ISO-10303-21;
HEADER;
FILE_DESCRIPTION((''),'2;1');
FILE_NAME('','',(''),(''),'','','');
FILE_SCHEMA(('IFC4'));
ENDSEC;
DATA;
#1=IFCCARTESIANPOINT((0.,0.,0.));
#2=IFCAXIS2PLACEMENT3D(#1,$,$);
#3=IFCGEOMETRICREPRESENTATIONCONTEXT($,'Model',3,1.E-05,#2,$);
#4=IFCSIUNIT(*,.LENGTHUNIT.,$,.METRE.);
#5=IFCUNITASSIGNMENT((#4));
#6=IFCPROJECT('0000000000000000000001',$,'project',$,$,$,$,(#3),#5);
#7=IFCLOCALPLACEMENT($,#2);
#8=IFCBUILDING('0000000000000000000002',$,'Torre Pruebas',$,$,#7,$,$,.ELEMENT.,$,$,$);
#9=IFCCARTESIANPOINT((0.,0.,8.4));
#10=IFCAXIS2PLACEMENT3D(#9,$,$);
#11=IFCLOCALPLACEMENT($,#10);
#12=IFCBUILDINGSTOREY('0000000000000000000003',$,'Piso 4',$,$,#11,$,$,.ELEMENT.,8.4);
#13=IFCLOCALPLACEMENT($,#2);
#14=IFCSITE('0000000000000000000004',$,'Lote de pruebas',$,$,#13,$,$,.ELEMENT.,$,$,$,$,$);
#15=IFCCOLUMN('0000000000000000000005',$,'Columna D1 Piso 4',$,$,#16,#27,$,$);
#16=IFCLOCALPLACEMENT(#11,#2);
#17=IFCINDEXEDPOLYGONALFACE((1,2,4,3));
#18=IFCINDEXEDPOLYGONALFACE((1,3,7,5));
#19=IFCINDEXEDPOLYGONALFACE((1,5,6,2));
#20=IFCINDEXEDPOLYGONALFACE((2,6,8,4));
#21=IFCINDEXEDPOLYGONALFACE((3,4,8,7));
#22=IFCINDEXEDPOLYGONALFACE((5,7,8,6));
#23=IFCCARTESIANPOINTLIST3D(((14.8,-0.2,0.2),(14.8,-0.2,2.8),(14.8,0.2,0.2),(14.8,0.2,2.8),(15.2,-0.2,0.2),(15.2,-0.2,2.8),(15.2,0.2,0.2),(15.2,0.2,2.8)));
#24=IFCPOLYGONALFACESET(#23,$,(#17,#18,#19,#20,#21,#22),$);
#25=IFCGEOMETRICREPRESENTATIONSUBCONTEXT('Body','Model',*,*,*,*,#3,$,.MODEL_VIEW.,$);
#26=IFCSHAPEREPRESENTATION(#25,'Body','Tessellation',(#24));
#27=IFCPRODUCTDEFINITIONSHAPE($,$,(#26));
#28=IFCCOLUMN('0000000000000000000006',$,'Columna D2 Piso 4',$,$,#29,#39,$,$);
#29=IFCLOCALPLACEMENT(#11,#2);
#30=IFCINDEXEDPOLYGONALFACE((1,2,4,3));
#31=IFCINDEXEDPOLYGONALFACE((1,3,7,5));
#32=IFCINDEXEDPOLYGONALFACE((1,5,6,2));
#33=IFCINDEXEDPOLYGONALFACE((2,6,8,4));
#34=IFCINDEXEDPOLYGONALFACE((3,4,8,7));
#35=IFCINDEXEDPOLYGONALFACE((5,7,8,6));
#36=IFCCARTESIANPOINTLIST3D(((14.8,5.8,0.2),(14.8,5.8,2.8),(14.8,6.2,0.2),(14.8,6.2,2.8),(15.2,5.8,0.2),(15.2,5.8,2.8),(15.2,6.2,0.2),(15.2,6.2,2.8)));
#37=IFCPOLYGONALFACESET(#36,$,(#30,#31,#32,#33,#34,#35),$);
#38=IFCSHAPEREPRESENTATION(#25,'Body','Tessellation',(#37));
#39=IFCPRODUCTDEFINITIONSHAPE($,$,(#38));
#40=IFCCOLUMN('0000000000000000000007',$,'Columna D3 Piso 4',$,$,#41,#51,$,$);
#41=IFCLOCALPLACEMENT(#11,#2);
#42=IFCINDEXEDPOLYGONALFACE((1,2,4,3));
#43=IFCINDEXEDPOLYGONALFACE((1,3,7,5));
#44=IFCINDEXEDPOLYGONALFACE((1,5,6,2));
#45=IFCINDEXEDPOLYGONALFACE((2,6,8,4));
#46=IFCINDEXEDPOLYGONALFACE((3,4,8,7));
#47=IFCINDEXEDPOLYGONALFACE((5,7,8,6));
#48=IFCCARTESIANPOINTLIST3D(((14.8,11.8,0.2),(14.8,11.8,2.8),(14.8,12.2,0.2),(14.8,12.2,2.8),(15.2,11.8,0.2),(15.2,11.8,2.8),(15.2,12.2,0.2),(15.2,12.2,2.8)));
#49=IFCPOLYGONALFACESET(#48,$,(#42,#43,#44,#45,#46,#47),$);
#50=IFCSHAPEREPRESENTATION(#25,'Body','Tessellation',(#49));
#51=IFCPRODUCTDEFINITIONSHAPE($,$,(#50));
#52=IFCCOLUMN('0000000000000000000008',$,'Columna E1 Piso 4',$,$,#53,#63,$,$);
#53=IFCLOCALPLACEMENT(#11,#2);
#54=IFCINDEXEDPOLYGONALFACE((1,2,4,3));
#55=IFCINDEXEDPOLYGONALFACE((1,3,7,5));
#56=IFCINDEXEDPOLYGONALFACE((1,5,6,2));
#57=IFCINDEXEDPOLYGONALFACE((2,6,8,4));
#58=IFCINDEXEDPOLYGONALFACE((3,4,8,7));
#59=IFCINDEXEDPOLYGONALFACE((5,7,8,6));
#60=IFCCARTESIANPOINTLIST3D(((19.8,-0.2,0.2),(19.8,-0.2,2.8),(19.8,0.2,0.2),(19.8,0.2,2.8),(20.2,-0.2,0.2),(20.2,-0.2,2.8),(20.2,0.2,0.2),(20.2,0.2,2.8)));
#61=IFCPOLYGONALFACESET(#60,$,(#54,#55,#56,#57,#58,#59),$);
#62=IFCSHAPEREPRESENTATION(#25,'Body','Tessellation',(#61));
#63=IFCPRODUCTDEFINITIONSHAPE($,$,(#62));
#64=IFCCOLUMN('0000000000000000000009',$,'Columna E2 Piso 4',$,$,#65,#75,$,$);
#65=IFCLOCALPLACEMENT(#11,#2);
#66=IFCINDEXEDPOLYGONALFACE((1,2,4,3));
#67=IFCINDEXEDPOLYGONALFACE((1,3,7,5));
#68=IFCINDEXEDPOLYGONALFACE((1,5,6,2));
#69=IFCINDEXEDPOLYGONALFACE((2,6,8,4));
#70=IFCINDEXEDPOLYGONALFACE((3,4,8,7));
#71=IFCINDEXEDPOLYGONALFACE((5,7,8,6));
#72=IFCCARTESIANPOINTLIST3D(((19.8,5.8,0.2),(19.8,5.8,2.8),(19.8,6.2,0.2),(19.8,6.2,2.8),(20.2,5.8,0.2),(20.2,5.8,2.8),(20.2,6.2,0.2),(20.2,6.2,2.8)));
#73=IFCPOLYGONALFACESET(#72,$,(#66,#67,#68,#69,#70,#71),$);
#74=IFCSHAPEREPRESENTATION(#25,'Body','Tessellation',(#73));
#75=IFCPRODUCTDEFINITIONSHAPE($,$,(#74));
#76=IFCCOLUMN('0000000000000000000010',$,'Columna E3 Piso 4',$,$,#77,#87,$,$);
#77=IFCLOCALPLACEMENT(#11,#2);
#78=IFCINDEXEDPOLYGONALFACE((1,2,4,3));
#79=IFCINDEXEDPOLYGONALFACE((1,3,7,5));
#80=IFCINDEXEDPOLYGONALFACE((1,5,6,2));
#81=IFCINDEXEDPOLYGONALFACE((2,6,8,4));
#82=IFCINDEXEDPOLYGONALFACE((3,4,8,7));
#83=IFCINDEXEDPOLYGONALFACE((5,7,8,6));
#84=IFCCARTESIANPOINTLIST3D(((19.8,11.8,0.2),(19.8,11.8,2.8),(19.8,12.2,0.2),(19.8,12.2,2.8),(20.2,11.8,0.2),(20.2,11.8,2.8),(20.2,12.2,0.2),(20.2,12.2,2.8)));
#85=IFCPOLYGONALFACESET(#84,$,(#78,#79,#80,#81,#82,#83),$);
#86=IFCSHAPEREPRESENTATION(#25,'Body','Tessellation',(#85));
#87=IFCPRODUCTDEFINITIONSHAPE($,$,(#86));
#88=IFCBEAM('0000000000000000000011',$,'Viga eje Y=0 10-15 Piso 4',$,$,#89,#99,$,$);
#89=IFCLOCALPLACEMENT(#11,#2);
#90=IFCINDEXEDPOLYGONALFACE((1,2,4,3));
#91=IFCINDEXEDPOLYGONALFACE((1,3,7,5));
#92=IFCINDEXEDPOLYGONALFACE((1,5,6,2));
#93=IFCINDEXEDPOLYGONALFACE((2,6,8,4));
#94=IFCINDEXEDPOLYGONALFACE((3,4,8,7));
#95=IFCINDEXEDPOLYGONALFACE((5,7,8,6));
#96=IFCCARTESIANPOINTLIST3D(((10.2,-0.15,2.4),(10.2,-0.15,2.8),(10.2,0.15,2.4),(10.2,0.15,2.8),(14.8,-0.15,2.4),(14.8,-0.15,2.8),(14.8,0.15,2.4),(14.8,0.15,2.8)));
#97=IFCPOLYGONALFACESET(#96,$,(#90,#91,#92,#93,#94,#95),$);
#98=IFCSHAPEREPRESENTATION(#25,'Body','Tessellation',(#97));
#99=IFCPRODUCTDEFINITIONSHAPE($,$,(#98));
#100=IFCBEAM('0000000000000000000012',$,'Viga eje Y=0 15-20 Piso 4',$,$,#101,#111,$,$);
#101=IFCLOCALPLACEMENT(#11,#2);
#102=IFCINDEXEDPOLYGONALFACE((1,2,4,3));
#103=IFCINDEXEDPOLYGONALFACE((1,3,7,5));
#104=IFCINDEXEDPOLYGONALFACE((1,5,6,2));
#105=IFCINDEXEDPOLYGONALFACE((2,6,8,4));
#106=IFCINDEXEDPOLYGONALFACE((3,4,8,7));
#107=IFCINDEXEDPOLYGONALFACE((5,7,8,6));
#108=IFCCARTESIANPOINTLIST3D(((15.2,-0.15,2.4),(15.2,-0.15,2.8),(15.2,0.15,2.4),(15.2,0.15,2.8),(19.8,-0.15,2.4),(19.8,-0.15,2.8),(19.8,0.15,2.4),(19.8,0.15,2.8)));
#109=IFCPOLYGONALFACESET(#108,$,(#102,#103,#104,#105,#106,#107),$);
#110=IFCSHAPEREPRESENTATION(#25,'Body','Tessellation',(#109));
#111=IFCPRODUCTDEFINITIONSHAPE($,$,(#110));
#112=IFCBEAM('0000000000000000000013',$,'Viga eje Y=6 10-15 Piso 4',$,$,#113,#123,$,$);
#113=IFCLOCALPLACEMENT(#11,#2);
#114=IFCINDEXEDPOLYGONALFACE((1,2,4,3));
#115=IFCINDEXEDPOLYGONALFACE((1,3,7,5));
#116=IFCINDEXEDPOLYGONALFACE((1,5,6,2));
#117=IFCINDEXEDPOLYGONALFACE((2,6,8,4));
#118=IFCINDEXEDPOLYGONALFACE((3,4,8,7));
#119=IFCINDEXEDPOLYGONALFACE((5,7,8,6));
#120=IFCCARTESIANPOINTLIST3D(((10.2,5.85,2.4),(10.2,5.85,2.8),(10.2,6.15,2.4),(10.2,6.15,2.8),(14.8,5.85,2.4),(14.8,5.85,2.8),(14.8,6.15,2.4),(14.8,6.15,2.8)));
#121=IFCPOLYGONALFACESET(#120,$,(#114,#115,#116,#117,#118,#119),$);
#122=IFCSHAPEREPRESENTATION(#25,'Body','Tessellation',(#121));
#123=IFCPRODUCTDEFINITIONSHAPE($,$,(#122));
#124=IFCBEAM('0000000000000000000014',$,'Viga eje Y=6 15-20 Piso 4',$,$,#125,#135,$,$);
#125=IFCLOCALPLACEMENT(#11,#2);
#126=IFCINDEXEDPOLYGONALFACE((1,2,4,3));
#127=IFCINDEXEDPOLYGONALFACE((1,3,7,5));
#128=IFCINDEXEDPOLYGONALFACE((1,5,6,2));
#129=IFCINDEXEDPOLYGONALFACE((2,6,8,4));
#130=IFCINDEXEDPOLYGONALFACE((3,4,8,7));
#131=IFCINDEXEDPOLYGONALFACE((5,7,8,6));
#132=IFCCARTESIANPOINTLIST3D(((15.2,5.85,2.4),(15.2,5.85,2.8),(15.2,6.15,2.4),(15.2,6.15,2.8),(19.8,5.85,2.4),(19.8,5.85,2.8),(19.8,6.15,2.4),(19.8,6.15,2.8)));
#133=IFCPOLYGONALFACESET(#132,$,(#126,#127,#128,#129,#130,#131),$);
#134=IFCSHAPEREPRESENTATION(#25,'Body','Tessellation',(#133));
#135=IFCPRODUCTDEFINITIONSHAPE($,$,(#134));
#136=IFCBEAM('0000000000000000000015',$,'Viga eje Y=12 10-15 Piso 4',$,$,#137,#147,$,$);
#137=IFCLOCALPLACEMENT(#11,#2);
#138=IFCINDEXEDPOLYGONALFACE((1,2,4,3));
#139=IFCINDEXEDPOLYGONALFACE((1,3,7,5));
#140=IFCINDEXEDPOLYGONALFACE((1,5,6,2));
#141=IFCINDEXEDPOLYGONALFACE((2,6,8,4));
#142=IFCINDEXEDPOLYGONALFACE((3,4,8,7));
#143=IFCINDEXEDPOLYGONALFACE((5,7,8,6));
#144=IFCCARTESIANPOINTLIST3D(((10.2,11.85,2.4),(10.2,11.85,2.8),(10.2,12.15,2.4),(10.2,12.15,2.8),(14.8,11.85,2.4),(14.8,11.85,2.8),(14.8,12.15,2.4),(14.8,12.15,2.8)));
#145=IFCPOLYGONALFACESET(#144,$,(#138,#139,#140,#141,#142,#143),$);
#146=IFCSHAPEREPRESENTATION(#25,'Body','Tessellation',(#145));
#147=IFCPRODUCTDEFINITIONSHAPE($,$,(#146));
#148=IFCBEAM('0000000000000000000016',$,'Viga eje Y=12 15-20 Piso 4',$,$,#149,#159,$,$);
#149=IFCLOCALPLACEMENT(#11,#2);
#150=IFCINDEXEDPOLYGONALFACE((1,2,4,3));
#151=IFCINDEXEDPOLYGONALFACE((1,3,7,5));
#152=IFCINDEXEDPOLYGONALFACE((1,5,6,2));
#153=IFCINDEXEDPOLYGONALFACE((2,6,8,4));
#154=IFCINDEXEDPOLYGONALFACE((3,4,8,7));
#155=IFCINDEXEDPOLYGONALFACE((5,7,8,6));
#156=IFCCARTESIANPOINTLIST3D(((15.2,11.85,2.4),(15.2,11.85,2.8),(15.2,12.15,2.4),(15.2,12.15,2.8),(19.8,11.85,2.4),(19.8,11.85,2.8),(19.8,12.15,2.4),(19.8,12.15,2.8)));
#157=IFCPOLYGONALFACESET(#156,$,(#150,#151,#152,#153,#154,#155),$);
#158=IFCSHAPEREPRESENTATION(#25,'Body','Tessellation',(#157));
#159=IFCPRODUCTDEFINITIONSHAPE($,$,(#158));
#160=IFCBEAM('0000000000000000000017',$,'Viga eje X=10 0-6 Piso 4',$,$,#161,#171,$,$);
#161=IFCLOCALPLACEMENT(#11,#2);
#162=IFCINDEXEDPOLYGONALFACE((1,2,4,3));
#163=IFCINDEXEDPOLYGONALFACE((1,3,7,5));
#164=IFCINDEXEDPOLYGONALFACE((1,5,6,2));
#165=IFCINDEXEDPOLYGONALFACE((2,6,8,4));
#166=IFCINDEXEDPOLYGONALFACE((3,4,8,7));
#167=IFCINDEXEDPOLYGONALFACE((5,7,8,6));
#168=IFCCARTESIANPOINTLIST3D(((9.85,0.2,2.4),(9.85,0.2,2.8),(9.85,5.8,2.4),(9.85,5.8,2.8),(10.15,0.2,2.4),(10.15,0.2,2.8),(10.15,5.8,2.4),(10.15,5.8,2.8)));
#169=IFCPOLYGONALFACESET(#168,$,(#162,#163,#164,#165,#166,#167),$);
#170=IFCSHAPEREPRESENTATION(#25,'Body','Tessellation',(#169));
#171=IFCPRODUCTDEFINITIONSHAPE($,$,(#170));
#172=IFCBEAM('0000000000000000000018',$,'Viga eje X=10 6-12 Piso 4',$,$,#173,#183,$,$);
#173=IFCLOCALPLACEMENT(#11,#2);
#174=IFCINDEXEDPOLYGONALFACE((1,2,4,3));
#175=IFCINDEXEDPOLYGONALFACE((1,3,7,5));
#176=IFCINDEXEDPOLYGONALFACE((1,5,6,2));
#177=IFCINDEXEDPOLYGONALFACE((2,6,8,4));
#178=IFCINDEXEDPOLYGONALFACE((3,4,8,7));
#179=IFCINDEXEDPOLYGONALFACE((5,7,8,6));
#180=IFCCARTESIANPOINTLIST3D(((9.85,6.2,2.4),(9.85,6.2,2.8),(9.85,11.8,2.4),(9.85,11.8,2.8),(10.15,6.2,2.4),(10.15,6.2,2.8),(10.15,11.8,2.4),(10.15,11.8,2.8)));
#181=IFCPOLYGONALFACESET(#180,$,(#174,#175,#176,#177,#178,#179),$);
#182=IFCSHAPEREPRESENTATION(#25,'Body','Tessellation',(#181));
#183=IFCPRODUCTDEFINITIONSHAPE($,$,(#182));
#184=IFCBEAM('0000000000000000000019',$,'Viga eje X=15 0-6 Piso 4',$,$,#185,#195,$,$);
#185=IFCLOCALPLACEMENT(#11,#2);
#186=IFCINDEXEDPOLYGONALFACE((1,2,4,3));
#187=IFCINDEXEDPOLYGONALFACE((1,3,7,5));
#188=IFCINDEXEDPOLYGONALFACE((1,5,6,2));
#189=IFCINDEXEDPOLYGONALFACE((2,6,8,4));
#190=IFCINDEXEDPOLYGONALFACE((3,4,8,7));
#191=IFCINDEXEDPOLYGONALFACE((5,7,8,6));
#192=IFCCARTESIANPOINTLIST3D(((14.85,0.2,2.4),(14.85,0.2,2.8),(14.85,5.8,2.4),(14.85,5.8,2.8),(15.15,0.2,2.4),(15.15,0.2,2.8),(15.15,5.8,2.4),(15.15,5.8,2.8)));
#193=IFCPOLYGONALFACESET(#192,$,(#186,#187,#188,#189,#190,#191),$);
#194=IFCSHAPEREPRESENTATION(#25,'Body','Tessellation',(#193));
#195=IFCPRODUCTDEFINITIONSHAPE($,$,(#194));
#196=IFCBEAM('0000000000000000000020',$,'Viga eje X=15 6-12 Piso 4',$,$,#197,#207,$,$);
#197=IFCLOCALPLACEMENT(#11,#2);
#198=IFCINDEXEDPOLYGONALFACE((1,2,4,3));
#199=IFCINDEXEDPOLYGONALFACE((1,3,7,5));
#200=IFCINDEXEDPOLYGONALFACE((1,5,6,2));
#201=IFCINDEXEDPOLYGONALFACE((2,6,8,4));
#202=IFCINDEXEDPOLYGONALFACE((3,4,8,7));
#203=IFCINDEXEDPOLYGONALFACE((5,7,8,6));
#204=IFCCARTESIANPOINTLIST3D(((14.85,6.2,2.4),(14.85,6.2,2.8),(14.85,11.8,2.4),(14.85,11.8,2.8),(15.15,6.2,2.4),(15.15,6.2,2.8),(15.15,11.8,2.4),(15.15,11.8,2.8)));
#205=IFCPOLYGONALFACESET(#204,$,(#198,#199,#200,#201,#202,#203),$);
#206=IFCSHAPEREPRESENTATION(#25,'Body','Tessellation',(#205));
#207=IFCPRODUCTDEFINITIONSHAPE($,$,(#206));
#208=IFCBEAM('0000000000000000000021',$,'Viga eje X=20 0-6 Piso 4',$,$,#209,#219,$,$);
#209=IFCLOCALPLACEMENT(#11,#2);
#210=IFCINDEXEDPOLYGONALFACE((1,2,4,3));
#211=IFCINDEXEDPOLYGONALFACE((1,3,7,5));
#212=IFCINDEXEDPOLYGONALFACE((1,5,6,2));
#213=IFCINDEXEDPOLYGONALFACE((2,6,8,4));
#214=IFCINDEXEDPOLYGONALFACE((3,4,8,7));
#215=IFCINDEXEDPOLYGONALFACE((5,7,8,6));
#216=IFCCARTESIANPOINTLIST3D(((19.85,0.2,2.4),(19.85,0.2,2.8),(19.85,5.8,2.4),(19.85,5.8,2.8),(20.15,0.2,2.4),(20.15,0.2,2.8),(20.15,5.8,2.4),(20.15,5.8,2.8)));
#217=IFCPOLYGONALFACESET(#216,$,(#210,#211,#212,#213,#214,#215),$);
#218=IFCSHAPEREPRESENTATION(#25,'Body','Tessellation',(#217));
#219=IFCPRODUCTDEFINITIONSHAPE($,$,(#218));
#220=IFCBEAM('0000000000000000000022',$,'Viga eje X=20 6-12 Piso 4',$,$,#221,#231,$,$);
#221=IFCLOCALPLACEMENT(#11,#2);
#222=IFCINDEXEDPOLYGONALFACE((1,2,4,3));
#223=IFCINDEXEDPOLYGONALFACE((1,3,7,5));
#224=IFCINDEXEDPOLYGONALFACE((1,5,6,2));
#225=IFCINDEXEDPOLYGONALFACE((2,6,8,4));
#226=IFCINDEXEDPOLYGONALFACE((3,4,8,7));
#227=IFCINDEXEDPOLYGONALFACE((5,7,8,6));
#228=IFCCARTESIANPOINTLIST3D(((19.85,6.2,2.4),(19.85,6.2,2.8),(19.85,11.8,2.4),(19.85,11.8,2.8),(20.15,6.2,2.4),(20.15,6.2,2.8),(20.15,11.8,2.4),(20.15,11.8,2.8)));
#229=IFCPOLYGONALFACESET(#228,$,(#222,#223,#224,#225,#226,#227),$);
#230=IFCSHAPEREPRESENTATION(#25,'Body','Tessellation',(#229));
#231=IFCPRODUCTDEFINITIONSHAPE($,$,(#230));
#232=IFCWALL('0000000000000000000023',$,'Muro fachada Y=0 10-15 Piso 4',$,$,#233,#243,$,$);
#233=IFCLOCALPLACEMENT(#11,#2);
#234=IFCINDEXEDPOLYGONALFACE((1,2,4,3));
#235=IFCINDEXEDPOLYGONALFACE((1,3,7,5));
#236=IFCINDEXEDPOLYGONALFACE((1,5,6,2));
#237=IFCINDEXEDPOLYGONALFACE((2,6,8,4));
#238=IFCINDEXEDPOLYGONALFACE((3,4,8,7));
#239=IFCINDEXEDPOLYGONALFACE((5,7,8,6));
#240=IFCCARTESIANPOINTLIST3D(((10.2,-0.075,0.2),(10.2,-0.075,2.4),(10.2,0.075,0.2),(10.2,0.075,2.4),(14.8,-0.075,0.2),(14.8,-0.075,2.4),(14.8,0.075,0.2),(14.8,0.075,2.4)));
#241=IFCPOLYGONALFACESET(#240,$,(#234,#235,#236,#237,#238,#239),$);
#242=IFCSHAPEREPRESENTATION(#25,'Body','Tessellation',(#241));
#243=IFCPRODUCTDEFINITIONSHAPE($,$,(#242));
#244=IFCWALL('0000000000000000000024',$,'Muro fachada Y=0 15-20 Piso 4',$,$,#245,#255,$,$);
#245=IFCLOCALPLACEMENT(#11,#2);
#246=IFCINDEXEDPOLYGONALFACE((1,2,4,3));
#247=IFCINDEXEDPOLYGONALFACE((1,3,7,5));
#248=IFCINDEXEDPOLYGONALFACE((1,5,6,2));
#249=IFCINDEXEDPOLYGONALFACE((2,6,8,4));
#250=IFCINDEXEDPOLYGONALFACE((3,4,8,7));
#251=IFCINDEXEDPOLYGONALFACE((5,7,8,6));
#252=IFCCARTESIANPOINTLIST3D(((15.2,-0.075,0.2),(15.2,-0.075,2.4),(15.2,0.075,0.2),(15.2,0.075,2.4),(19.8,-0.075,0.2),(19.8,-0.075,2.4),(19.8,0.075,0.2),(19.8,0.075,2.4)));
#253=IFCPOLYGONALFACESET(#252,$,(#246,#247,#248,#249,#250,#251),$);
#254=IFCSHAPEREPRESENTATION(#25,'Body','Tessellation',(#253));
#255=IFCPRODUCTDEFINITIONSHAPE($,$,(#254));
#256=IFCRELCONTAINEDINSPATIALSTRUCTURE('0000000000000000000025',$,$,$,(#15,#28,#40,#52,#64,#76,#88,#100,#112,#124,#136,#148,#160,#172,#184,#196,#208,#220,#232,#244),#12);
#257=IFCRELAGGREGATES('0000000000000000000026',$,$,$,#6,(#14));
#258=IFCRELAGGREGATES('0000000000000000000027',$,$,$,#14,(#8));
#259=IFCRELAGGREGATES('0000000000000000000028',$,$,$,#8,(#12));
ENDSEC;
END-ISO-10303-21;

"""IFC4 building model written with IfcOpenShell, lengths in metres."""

from ifc_helpers import new_model, si_unit, frame, origin, origin_2d, place, context, subcontext, project, spatial, rectangle, extrude, element, save


model = new_model("IFC4")

# Units and contexts
model_context = context("Model", 3, precision=1e-05, world=origin())
body_context = subcontext(model_context, "Body", "Model", "MODEL_VIEW")
ifc_project = project(units=[si_unit("LENGTHUNIT", "METRE")], contexts=[model_context])

# Site, building, storey
site_placement = place(None, origin())
site = spatial("IfcSite", under=ifc_project, at=site_placement, Name="Lote de pruebas", CompositionType="ELEMENT")
building_placement = place(None, origin())
building = spatial("IfcBuilding", under=site, at=building_placement, Name="Torre Pruebas", CompositionType="ELEMENT")
storey_placement = place(None, frame((0.0, 0.0, 8.4)))
storey = spatial("IfcBuildingStorey", under=building, at=storey_placement, Name="Piso 4", CompositionType="ELEMENT", Elevation=8.4)

# Columns
for number, where, name in (
    (1, (15.0, 0.0, 8.6), "Columna D1 Piso 4"),
    (2, (15.0, 6.0, 8.6), "Columna D2 Piso 4"),
    (3, (15.0, 12.0, 8.6), "Columna D3 Piso 4"),
    (4, (20.0, 0.0, 8.6), "Columna E1 Piso 4"),
    (5, (20.0, 6.0, 8.6), "Columna E2 Piso 4"),
    (6, (20.0, 12.0, 8.6), "Columna E3 Piso 4"),
):
    element("IfcColumn", number, at=place(None, frame(where)), inside=storey, Name=name, context=body_context, shape_type="SweptSolid", body=[
        extrude(rectangle(XDim=0.4, YDim=0.4, at=origin_2d()), origin(), (0.0, 0.0, 1.0), 2.6),
    ])

# Beams
for number, where, name in (
    (7, (12.5, 0.0, 10.8), "Viga eje Y=0 10-15 Piso 4"),
    (8, (17.5, 0.0, 10.8), "Viga eje Y=0 15-20 Piso 4"),
    (9, (12.5, 6.0, 10.8), "Viga eje Y=6 10-15 Piso 4"),
    (10, (17.5, 6.0, 10.8), "Viga eje Y=6 15-20 Piso 4"),
    (11, (12.5, 12.0, 10.8), "Viga eje Y=12 10-15 Piso 4"),
    (12, (17.5, 12.0, 10.8), "Viga eje Y=12 15-20 Piso 4"),
):
    element("IfcBeam", number, at=place(None, frame(where)), inside=storey, Name=name, context=body_context, shape_type="SweptSolid", body=[
        extrude(rectangle(XDim=4.6, YDim=0.3, at=origin_2d()), origin(), (0.0, 0.0, 1.0), 0.4),
    ])
for number, where, name in (
    (13, (10.0, 3.0, 10.8), "Viga eje X=10 0-6 Piso 4"),
    (14, (10.0, 9.0, 10.8), "Viga eje X=10 6-12 Piso 4"),
    (15, (15.0, 3.0, 10.8), "Viga eje X=15 0-6 Piso 4"),
    (16, (15.0, 9.0, 10.8), "Viga eje X=15 6-12 Piso 4"),
    (17, (20.0, 3.0, 10.8), "Viga eje X=20 0-6 Piso 4"),
    (18, (20.0, 9.0, 10.8), "Viga eje X=20 6-12 Piso 4"),
):
    element("IfcBeam", number, at=place(None, frame(where)), inside=storey, Name=name, context=body_context, shape_type="SweptSolid", body=[
        extrude(rectangle(XDim=0.3, YDim=5.6, at=origin_2d()), origin(), (0.0, 0.0, 1.0), 0.4),
    ])

# Walls
for number, where, name in (
    (19, (12.5, 0.0, 8.6), "Muro fachada Y=0 10-15 Piso 4"),
    (20, (17.5, 0.0, 8.6), "Muro fachada Y=0 15-20 Piso 4"),
):
    element("IfcWall", number, at=place(None, frame(where)), inside=storey, Name=name, context=body_context, shape_type="SweptSolid", body=[
        extrude(rectangle(XDim=4.6, YDim=0.15, at=origin_2d()), origin(), (0.0, 0.0, 1.0), 2.2),
    ])

save(model, "model.ifc")
